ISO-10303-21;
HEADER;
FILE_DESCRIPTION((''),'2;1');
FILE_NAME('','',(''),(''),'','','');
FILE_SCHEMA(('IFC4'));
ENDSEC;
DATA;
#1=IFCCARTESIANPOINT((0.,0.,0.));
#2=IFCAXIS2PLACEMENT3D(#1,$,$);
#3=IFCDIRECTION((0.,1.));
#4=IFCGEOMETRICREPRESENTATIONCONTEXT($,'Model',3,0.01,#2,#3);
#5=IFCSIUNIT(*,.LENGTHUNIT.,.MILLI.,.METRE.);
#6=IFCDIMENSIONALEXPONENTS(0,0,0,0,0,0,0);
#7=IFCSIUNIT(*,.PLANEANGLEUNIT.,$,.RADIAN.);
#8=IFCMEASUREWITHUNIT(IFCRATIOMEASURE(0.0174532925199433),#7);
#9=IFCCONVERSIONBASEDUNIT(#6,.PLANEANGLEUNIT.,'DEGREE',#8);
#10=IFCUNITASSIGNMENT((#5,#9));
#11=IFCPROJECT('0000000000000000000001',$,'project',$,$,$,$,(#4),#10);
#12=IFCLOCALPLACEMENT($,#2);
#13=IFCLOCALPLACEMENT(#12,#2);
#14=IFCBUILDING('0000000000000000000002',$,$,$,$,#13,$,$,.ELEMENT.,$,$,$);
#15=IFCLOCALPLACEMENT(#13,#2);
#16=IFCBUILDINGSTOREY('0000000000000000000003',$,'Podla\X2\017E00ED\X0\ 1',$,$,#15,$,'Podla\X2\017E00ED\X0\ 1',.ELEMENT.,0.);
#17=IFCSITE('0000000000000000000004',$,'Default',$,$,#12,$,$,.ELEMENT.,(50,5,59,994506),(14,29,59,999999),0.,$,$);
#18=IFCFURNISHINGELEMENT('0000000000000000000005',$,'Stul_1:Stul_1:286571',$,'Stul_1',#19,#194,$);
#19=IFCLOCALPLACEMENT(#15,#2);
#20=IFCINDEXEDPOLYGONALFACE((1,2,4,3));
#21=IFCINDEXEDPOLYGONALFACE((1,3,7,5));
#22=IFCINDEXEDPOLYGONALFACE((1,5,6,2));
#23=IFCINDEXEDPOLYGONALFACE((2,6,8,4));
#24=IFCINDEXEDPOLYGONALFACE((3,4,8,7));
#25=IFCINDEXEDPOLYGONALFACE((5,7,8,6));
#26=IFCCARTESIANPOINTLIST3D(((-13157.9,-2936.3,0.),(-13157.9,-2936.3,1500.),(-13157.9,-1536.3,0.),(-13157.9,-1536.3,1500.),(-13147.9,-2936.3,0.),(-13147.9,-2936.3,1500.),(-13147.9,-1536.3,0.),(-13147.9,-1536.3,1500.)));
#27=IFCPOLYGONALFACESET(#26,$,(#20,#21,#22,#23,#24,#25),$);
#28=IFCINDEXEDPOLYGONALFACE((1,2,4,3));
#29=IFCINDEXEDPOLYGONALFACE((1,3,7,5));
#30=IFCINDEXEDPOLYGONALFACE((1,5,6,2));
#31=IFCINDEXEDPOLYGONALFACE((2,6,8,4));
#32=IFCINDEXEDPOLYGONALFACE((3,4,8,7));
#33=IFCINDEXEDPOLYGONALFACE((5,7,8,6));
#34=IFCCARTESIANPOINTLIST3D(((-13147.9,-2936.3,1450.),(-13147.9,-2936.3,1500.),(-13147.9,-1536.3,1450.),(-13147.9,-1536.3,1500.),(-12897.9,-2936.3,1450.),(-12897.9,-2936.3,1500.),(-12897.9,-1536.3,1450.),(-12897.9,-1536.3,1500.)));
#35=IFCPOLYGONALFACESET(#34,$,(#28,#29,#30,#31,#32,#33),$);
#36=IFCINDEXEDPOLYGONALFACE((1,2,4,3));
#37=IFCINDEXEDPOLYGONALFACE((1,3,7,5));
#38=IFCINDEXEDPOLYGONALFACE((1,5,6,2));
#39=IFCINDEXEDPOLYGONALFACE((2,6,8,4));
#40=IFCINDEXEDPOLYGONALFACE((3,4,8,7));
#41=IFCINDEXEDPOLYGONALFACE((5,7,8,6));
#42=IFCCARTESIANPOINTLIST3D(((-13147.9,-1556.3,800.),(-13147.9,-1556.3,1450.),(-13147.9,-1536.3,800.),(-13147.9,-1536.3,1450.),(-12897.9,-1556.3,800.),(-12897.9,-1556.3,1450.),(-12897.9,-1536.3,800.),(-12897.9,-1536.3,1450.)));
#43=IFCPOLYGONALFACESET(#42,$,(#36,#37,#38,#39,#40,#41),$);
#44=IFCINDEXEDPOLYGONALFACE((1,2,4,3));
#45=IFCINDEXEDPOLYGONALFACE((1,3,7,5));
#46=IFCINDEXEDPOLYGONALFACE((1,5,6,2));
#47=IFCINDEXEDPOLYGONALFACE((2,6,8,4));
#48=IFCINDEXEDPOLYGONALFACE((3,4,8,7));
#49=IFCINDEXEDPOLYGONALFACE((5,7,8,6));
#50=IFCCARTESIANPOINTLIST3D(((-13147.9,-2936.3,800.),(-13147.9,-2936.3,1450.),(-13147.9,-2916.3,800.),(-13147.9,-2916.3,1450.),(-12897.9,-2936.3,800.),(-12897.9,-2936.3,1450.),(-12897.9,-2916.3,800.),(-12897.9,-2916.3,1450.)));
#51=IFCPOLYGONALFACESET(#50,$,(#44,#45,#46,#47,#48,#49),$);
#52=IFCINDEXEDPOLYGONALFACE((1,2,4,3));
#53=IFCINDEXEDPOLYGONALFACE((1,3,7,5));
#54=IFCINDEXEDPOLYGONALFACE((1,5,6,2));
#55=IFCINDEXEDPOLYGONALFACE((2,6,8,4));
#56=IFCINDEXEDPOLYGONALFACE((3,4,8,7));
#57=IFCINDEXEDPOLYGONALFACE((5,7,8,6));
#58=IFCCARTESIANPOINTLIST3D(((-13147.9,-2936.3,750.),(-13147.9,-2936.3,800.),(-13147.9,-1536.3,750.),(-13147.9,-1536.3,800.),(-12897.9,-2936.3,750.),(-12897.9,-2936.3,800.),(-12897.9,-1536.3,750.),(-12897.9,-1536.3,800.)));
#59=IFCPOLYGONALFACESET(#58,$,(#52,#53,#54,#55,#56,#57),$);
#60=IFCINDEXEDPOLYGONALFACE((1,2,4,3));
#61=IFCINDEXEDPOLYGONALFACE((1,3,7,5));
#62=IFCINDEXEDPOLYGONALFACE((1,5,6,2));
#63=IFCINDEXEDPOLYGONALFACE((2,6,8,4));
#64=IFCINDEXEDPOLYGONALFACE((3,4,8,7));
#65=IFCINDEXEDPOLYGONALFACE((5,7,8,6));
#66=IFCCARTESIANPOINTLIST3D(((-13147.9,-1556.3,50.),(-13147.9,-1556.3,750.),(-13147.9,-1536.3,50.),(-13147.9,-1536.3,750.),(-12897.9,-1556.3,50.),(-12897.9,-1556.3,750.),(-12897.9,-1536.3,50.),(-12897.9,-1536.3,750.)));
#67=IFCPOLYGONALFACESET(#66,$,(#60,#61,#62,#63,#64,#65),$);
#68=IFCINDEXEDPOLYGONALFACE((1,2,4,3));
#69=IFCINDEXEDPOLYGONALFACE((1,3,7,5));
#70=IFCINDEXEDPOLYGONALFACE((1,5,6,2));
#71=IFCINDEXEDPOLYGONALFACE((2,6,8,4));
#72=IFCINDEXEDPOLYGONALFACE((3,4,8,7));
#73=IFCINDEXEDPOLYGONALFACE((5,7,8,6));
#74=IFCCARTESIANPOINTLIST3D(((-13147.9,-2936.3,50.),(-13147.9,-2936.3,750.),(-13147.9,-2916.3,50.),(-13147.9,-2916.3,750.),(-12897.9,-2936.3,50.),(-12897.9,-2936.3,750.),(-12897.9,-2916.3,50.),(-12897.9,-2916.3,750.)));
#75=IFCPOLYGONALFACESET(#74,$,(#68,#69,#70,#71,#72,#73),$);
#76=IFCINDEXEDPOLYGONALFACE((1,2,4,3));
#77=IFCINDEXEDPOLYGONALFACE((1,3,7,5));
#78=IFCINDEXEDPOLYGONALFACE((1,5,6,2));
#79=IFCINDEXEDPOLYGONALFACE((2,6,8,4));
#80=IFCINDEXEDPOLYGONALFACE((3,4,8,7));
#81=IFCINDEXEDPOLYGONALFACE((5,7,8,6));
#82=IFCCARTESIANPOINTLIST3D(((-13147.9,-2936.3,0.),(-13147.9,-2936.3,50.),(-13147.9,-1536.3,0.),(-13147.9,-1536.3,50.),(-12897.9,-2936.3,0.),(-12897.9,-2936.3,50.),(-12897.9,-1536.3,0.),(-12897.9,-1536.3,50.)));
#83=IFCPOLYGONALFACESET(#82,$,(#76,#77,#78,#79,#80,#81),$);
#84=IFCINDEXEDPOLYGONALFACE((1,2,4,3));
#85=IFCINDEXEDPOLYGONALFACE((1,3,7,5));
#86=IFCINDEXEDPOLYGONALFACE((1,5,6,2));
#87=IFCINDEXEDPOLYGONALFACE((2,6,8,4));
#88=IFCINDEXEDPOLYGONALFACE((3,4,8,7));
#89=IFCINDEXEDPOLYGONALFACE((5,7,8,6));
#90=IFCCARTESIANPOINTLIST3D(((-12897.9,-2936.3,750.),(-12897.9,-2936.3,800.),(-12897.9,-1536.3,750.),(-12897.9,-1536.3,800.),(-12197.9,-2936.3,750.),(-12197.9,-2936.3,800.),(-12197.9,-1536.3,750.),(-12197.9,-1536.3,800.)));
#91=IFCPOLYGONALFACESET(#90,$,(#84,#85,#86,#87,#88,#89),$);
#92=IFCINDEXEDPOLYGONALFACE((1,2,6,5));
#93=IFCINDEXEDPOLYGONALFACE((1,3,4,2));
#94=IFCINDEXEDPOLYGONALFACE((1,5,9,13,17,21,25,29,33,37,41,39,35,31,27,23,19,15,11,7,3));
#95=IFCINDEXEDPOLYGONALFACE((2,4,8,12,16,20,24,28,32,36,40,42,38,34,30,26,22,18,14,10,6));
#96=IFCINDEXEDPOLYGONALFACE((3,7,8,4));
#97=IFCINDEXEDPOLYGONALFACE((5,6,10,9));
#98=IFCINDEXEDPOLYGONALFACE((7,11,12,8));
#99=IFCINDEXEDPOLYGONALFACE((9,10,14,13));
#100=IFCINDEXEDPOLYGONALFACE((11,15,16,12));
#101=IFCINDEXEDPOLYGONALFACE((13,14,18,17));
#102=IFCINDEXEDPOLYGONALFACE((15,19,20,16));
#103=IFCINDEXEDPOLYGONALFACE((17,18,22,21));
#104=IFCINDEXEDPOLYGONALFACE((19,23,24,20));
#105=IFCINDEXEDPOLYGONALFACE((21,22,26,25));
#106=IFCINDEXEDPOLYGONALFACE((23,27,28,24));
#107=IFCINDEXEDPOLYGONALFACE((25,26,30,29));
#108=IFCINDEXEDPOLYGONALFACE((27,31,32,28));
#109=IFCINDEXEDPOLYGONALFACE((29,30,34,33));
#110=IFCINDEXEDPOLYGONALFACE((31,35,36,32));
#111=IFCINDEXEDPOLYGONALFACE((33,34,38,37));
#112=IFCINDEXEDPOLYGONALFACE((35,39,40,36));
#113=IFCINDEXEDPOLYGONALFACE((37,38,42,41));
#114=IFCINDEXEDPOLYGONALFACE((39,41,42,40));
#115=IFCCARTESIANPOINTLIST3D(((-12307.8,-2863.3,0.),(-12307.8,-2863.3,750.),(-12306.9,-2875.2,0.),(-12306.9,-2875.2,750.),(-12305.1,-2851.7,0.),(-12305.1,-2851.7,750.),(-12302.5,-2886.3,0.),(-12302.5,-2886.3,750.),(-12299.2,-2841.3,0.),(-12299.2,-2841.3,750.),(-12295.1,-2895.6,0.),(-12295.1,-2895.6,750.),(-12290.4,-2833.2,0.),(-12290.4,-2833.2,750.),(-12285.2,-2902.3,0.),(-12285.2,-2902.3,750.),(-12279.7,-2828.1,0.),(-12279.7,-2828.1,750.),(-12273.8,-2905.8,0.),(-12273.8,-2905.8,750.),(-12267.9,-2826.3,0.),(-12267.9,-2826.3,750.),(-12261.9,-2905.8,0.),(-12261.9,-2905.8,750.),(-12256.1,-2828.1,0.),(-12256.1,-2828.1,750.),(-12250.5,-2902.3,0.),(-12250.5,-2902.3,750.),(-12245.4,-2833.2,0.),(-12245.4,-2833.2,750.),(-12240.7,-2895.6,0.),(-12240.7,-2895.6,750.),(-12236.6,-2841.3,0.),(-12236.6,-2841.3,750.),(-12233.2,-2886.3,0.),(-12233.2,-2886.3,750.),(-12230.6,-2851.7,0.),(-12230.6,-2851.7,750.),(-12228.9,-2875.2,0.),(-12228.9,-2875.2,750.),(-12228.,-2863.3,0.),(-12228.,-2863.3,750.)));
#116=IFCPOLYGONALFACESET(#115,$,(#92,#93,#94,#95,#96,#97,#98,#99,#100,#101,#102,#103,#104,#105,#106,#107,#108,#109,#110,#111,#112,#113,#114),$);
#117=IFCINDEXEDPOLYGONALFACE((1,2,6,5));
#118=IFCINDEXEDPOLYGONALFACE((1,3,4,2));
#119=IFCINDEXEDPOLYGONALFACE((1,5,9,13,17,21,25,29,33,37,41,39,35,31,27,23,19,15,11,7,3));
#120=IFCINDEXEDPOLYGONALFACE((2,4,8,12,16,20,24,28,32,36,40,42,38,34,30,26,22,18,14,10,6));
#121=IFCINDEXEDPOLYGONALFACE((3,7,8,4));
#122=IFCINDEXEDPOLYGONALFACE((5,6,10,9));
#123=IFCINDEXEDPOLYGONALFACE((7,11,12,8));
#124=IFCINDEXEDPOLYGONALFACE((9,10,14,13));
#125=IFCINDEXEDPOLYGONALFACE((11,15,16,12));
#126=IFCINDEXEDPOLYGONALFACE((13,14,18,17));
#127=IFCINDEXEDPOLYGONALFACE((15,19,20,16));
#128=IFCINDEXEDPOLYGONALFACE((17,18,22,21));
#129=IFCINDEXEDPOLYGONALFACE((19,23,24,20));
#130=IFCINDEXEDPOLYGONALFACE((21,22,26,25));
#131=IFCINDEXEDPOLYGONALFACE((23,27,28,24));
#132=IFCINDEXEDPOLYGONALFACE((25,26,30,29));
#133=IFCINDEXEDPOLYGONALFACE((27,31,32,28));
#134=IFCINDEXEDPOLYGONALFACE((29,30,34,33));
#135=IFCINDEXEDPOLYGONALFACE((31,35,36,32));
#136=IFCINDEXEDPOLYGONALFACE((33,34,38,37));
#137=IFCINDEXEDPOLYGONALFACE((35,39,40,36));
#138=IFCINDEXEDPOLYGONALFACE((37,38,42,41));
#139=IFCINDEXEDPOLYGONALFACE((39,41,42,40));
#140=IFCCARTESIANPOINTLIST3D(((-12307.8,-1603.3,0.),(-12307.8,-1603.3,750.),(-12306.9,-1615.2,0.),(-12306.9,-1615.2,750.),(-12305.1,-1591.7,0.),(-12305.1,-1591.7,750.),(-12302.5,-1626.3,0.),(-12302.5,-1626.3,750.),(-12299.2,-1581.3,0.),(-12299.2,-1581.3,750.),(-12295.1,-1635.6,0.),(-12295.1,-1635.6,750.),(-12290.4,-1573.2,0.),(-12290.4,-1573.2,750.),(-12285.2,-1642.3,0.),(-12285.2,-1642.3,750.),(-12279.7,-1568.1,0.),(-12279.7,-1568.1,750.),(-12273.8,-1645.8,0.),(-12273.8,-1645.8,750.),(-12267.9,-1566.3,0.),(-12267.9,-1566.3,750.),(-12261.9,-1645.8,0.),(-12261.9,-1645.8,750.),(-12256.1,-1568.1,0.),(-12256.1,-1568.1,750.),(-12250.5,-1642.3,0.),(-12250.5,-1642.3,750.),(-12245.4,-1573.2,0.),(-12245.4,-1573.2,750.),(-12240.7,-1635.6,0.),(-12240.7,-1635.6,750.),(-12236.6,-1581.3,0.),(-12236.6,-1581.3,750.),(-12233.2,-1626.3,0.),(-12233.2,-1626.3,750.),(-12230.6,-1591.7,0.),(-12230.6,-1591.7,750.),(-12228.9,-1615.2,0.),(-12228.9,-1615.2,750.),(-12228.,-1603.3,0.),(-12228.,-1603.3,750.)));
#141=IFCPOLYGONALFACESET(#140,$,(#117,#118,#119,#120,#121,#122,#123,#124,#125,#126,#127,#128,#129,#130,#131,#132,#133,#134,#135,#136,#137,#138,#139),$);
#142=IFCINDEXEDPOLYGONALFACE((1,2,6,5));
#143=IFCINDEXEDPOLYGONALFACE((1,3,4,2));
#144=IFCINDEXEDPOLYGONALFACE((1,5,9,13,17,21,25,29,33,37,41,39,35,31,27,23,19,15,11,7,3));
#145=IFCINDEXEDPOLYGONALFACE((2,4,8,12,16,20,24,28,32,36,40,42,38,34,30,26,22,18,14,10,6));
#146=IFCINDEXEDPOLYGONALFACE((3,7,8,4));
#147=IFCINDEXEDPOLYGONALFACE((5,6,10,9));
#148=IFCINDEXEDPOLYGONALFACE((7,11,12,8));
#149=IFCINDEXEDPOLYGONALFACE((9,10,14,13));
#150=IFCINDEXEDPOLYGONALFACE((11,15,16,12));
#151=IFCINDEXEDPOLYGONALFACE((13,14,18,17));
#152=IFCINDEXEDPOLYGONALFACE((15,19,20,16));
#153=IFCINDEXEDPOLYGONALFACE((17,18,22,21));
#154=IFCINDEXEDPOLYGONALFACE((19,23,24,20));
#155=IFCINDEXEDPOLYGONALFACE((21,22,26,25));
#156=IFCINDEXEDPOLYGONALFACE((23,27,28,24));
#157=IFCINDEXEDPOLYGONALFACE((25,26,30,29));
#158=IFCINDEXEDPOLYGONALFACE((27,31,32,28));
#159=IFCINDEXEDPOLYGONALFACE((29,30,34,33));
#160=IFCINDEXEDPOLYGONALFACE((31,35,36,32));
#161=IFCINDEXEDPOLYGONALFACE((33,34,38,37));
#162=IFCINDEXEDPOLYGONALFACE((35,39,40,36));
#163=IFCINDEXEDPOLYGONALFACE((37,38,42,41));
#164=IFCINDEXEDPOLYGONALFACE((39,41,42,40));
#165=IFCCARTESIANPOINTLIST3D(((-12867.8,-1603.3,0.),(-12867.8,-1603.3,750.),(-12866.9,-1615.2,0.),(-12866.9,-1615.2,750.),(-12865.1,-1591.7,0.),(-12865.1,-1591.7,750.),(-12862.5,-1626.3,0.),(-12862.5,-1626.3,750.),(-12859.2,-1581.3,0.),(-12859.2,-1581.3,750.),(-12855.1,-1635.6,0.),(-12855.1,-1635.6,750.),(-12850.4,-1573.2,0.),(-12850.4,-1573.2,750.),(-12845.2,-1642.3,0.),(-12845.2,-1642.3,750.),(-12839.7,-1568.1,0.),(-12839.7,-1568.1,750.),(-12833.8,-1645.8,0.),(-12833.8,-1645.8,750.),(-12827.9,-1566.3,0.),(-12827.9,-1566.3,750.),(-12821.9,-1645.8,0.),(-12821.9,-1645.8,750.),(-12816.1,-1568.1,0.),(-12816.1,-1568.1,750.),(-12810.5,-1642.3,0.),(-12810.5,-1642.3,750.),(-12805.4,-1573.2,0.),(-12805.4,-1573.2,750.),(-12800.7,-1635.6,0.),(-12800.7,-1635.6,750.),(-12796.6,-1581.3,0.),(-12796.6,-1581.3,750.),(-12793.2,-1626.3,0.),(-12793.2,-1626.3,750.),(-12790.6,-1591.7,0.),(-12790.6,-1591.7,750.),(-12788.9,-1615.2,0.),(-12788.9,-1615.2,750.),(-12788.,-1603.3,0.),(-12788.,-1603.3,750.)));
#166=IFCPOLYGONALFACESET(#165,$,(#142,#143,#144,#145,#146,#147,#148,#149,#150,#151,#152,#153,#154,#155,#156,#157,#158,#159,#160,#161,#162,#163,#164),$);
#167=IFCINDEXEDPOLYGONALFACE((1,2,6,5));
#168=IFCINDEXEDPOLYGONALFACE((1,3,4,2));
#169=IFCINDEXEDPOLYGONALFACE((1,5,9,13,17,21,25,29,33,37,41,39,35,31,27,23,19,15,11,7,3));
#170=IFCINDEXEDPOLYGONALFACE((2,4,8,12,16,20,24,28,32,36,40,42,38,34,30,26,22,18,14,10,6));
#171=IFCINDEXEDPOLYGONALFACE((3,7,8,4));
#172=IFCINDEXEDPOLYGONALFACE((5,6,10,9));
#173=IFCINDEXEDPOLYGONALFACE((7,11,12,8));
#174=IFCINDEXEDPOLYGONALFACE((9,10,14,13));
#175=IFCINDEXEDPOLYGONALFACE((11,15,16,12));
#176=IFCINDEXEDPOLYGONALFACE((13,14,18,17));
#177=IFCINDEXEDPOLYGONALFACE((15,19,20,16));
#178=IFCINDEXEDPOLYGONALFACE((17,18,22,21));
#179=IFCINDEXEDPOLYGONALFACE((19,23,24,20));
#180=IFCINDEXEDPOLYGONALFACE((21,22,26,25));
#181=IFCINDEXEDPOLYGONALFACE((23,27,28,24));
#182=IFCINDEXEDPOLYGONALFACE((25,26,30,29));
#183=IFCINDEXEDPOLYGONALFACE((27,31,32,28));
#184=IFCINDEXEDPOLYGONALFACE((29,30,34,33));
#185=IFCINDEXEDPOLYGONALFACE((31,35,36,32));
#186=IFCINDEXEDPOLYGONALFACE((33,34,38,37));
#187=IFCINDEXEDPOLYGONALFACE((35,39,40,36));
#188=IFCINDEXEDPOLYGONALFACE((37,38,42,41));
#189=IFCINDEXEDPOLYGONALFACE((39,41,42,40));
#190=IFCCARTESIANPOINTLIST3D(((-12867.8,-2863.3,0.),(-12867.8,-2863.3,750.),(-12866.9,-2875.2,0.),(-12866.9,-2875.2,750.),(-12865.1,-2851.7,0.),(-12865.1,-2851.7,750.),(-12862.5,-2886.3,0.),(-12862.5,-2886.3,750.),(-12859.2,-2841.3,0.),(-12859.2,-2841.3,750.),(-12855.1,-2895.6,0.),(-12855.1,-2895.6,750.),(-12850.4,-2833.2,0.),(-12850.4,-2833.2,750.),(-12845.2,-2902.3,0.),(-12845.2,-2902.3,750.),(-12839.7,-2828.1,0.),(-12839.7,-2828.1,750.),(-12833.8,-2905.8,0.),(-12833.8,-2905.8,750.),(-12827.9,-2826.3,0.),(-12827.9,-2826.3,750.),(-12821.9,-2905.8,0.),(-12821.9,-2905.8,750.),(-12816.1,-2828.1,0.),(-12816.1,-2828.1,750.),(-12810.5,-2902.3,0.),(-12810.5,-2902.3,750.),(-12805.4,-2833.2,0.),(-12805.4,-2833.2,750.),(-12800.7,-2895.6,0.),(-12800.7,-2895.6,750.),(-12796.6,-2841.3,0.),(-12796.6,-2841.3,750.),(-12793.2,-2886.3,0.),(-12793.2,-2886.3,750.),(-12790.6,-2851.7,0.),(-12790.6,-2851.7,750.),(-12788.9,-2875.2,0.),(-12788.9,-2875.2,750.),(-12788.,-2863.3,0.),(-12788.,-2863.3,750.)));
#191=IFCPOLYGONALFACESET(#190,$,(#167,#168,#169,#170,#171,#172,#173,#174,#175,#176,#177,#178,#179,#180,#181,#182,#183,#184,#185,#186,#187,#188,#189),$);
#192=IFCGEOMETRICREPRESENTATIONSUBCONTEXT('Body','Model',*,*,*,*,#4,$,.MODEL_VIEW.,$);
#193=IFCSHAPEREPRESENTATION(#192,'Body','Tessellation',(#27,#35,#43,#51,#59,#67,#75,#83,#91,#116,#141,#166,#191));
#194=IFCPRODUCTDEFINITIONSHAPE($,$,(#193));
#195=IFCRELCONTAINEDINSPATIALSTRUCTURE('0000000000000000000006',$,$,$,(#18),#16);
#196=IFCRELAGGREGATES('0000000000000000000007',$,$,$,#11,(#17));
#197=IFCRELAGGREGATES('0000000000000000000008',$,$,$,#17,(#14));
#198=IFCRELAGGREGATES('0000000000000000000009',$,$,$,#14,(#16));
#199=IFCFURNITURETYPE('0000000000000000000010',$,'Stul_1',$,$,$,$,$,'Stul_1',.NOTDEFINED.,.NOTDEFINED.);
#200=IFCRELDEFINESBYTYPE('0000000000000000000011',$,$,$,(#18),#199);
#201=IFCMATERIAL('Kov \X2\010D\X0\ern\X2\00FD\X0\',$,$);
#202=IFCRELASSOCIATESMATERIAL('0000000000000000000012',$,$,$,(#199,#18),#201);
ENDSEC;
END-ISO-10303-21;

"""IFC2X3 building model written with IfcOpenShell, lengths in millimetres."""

from ifc_helpers import new_model, entity, si_unit, converted_unit, direction, frame, frame_2d, origin, origin_2d_with_axis, place, context, subcontext, project, spatial, rectangle, circle, extrude, source, transform, mapped, material, type_object, type_shapes, element, save


model = new_model("IFC2X3")

# Units and contexts
model_context = context("Model", 3, precision=0.01, world=origin(), true_north=direction((0.0, 1.0)))
body_context = subcontext(model_context, "Body", "Model", "MODEL_VIEW")
ifc_project = project(units=[si_unit("LENGTHUNIT", "METRE", prefix="MILLI"), converted_unit("PLANEANGLEUNIT", "DEGREE", entity("IfcRatioMeasure", 0.0174532925199433), si_unit("PLANEANGLEUNIT", "RADIAN"), dimensions=[0, 0, 0, 0, 0, 0, 0])], contexts=[model_context])

# Site, building, storey
site_placement = place(None, origin())
site = spatial("IfcSite", under=ifc_project, at=site_placement, Name="Default", CompositionType="ELEMENT", RefLatitude=(50, 5, 59, 994506), RefLongitude=(14, 29, 59, 999999), RefElevation=0.0)
building_placement = place(site_placement, origin())
building = spatial("IfcBuilding", under=site, at=building_placement, CompositionType="ELEMENT")
storey_placement = place(building_placement, origin())
storey = spatial("IfcBuildingStorey", under=building, at=storey_placement, Name="Podlaží 1", LongName="Podlaží 1", CompositionType="ELEMENT", Elevation=0.0)

# Furnishing element
ifc_material_1 = material(Name="Kov černý")
furniture_type = type_object("IfcFurnitureType", Name="Stul_1", ElementType="Stul_1", material=ifc_material_1)
shared_shape_1 = source(origin(), body_context, "Body", "SweptSolid", [
    extrude(rectangle(XDim=1400.0, YDim=10.0, at=origin_2d_with_axis()), frame((0.0, 605.0, 0.0), z_axis=(0.0, 0.0, 1.0), x_axis=(-1.0, 0.0, 0.0)), (0.0, 0.0, 1.0), 1500.0),
    extrude(rectangle(XDim=1400.0, YDim=250.0, at=frame_2d((0.0, 0.0), x_axis=(1.0, 0.0))), frame((0.0, 475.0, 1450.0), z_axis=(0.0, 0.0, 1.0), x_axis=(-1.0, 0.0, 0.0)), (0.0, 0.0, 1.0), 50.0),
    extrude(rectangle(XDim=20.0, YDim=250.0, at=origin_2d_with_axis()), frame((690.0, 475.0, 800.0), z_axis=(0.0, 0.0, 1.0), x_axis=(-1.0, 0.0, 0.0)), (0.0, 0.0, 1.0), 650.0),
    extrude(rectangle(XDim=20.0, YDim=250.0, at=frame_2d((0.0, 0.0), x_axis=(1.0, 0.0))), frame((-690.0, 475.0, 800.0), z_axis=(0.0, 0.0, 1.0), x_axis=(-1.0, 0.0, 0.0)), (0.0, 0.0, 1.0), 650.0),
    extrude(rectangle(XDim=1400.0, YDim=250.0, at=origin_2d_with_axis()), frame((0.0, 475.0, 750.0), z_axis=(0.0, 0.0, 1.0), x_axis=(-1.0, 0.0, 0.0)), (0.0, 0.0, 1.0), 50.0),
    extrude(rectangle(XDim=20.0, YDim=250.0, at=origin_2d_with_axis()), frame((690.0, 475.0, 50.0), z_axis=(0.0, 0.0, 1.0), x_axis=(-1.0, 0.0, 0.0)), (0.0, 0.0, 1.0), 700.0),
    extrude(rectangle(XDim=20.0, YDim=250.0, at=frame_2d((0.0, 0.0), x_axis=(1.0, 0.0))), frame((-690.0, 475.0, 50.0), z_axis=(0.0, 0.0, 1.0), x_axis=(-1.0, 0.0, 0.0)), (0.0, 0.0, 1.0), 700.0),
    extrude(rectangle(XDim=1400.0, YDim=250.0, at=origin_2d_with_axis()), frame((0.0, 475.0, 0.0), z_axis=(0.0, 0.0, 1.0), x_axis=(-1.0, 0.0, 0.0)), (0.0, 0.0, 1.0), 50.0),
    extrude(rectangle(XDim=1400.0, YDim=700.0, at=origin_2d_with_axis()), frame((0.0, 0.0, 750.0), z_axis=(0.0, 0.0, 1.0), x_axis=(-1.0, 0.0, 0.0)), (0.0, 0.0, 1.0), 50.0),
    extrude(circle(Radius=40.0, at=frame_2d((0.0, 0.0), x_axis=(1.0, 0.0))), frame((-630.0, -280.0, 0.0)), (0.0, 0.0, 1.0), 750.0),
    extrude(circle(Radius=40.0, at=frame_2d((0.0, 0.0), x_axis=(1.0, 0.0))), frame((630.0, -280.0, 0.0)), (0.0, 0.0, 1.0), 750.0),
    extrude(circle(Radius=40.0, at=frame_2d((0.0, 0.0), x_axis=(1.0, 0.0))), frame((630.0, 280.0, 0.0)), (0.0, 0.0, 1.0), 750.0),
    extrude(circle(Radius=40.0, at=frame_2d((0.0, 0.0), x_axis=(1.0, 0.0))), frame((-630.0, 280.0, 0.0)), (0.0, 0.0, 1.0), 750.0),
])
type_shapes(furniture_type, [shared_shape_1])
for number, where, z_axis, x_axis, name in (
    (1, (-12547.9, -2236.3, 0.0), (0.0, 0.0, 1.0), (0.0, 1.0, 0.0), "Stul_1:Stul_1:286571"),
):
    element("IfcFurnishingElement", number, at=place(storey_placement, frame(where, z_axis=z_axis, x_axis=x_axis)), inside=storey, type_object=furniture_type, material=ifc_material_1, Name=name, ObjectType="Stul_1", context=body_context, shape_type="MappedRepresentation", body=[
        mapped(shared_shape_1, transform((0.0, 0.0, 0.0), scale=1.0)),
    ])

save(model, "model.ifc")
